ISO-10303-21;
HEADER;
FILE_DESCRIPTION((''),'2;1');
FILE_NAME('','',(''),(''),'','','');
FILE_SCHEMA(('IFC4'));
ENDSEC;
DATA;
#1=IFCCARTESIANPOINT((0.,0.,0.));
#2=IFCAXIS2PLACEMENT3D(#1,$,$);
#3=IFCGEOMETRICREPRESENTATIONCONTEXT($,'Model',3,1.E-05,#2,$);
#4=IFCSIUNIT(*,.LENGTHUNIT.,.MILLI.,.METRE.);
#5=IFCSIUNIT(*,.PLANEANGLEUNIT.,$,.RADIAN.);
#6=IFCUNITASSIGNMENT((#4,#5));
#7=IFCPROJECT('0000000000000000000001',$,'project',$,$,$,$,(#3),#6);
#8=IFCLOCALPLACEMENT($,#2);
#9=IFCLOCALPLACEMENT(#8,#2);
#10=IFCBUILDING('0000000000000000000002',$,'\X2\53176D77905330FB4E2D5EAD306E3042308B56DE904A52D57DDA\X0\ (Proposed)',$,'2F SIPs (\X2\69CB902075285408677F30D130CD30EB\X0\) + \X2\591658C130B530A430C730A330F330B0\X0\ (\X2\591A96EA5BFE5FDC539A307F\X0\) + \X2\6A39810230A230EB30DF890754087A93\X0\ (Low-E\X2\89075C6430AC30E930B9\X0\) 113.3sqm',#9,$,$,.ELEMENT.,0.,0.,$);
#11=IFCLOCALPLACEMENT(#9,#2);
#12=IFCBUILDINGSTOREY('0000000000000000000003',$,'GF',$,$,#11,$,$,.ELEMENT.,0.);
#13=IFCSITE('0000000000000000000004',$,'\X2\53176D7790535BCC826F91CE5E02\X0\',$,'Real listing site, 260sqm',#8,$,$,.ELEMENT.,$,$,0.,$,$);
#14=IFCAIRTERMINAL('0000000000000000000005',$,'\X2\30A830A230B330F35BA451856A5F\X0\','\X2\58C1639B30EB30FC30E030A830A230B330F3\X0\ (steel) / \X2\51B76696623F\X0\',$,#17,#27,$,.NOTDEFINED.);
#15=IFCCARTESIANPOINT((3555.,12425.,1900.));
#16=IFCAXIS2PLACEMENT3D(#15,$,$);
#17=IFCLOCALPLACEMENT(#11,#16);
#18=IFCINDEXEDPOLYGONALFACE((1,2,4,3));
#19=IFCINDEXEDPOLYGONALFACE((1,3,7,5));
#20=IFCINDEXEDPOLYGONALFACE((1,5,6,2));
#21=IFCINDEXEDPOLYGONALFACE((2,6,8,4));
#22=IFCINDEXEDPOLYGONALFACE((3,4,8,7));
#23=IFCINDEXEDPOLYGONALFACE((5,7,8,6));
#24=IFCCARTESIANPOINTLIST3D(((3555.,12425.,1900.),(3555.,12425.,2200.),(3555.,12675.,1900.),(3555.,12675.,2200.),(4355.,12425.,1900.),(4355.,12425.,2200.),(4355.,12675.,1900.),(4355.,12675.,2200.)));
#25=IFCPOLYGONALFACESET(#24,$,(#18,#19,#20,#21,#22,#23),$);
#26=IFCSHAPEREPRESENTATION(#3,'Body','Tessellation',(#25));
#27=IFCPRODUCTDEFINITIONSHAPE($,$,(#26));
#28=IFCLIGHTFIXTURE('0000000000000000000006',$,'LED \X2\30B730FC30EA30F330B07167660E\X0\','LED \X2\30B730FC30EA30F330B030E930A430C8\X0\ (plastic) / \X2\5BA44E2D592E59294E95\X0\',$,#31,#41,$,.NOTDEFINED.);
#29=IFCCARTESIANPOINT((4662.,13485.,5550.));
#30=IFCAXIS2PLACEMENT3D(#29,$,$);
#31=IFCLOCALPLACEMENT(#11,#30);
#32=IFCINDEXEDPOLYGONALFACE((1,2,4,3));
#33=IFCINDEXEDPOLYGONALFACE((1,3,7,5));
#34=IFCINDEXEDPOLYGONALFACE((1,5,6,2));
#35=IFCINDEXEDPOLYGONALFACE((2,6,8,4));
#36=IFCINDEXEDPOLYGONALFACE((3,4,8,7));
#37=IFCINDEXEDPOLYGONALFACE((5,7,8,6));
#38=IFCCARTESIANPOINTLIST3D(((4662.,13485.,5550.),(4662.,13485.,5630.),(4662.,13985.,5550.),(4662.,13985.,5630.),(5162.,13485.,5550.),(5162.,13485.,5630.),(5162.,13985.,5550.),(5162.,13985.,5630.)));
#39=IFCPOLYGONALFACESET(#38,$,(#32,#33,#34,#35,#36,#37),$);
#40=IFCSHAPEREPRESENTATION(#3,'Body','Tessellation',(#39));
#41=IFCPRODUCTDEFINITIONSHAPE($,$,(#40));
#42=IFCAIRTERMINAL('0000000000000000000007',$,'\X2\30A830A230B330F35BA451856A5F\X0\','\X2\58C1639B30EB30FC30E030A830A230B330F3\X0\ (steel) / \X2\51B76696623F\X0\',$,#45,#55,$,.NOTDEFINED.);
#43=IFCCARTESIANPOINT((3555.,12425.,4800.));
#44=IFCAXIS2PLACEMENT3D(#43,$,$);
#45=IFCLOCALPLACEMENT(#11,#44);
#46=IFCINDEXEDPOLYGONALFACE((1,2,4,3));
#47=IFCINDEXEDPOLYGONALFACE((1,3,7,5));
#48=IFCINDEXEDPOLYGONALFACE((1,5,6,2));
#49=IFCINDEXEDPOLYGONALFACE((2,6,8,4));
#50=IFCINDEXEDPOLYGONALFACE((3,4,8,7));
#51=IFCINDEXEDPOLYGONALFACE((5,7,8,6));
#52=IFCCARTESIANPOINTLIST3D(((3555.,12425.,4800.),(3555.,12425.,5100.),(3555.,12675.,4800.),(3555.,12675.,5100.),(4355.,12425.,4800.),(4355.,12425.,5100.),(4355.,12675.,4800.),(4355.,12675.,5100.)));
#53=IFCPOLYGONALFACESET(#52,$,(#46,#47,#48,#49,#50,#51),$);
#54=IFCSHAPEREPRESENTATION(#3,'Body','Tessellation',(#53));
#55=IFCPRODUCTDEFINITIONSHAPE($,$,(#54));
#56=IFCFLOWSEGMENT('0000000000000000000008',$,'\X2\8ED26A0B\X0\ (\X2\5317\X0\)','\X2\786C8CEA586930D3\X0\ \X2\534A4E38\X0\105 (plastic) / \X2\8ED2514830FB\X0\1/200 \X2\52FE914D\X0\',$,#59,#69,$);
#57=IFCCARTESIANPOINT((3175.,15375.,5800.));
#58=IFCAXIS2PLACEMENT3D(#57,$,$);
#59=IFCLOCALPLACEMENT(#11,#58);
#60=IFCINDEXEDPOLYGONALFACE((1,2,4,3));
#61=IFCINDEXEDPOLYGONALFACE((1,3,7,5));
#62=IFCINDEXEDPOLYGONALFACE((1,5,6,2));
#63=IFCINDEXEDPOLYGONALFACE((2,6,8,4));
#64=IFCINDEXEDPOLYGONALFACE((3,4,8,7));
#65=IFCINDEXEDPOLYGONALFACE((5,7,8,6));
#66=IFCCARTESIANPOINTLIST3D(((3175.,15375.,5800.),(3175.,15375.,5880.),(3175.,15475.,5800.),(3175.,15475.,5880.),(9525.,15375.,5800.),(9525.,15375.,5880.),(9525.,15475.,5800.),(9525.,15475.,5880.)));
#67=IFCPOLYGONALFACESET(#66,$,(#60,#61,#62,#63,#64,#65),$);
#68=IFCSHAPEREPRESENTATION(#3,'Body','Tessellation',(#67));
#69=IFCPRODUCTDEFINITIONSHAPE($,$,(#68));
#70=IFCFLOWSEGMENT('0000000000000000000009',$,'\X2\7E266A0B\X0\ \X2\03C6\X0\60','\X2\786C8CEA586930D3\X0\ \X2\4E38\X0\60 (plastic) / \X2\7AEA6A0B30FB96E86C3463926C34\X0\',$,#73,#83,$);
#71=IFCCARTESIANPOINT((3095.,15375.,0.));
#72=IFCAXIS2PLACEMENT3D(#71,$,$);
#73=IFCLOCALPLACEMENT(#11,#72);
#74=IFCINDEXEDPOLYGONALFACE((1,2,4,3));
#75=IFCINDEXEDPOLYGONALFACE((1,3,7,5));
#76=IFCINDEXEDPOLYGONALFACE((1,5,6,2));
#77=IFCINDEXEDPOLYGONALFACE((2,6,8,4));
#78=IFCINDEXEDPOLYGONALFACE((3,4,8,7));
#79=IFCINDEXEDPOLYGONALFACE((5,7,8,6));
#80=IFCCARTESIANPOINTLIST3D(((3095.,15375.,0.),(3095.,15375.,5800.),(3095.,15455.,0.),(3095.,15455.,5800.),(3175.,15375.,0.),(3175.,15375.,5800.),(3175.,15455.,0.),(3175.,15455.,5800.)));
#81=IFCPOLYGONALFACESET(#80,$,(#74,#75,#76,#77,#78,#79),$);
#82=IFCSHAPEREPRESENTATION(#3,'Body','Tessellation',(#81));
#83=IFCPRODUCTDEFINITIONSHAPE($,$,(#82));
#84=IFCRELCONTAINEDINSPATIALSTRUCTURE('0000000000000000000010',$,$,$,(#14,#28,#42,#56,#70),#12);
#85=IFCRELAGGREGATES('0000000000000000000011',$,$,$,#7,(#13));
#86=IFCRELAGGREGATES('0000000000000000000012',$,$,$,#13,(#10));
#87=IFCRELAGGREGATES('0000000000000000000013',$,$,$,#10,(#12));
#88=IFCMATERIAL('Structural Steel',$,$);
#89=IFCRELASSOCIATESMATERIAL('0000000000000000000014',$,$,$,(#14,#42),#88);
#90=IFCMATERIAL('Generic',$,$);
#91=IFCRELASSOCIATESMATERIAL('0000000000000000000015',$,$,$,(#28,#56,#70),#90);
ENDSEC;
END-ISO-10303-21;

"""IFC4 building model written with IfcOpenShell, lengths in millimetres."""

from ifc_helpers import new_model, si_unit, frame, frame_2d, origin, place, context, project, spatial, rectangle, extrude, material, element, save


model = new_model("IFC4")

# Units and contexts
model_context = context("Model", 3, precision=1e-05, world=origin())
ifc_project = project(units=[si_unit("LENGTHUNIT", "METRE", prefix="MILLI"), si_unit("PLANEANGLEUNIT", "RADIAN")], contexts=[model_context])

# Site, building, storey
site_placement = place(None, origin())
site = spatial("IfcSite", under=ifc_project, at=site_placement, Name="北海道富良野市", ObjectType="Real listing site, 260sqm", CompositionType="ELEMENT", RefElevation=0.0)
building_placement = place(site_placement, origin())
building = spatial("IfcBuilding", under=site, at=building_placement, Name="北海道・中庭のある回遊動線 (Proposed)", ObjectType="2F SIPs (構造用合板パネル) + 外壁サイディング (多雪対応厚み) + 樹脂アルミ複合窓 (Low-E複層ガラス) 113.3sqm", CompositionType="ELEMENT", ElevationOfRefHeight=0.0, ElevationOfTerrain=0.0)
storey_placement = place(building_placement, origin())
storey = spatial("IfcBuildingStorey", under=building, at=storey_placement, Name="GF", CompositionType="ELEMENT", Elevation=0.0)

# Shared definitions
ifc_material_1 = material(Name="Generic")

# Shared definitions
ifc_material_2 = material(Name="Structural Steel")

# Air terminal
air_terminal_1_placement = place(storey_placement, frame((3555.0, 12425.0, 1900.0)))
element("IfcAirTerminal", 1, at=air_terminal_1_placement, inside=storey, material=ifc_material_2, Name="エアコン室内機", Description="壁掛ルームエアコン (steel) / 冷暖房", PredefinedType="NOTDEFINED", context=model_context, shape_type="SweptSolid", body=[
    extrude(rectangle(XDim=800.0, YDim=250.0, at=frame_2d((400.0, 125.0))), frame((3555.0, 12425.0, 1900.0)), (0.0, 0.0, 1.0), 300.0),
])

# Light fixture
light_fixture_placement = place(storey_placement, frame((4662.0, 13485.0, 5550.0)))
element("IfcLightFixture", 2, at=light_fixture_placement, inside=storey, material=ifc_material_1, Name="LED シーリング照明", Description="LED シーリングライト (plastic) / 室中央天井", PredefinedType="NOTDEFINED", context=model_context, shape_type="SweptSolid", body=[
    extrude(rectangle(XDim=500.0, YDim=500.0, at=frame_2d((250.0, 250.0))), frame((4662.0, 13485.0, 5550.0)), (0.0, 0.0, 1.0), 80.0),
])

# Air terminal
air_terminal_2_placement = place(storey_placement, frame((3555.0, 12425.0, 4800.0)))
element("IfcAirTerminal", 3, at=air_terminal_2_placement, inside=storey, material=ifc_material_2, Name="エアコン室内機", Description="壁掛ルームエアコン (steel) / 冷暖房", PredefinedType="NOTDEFINED", context=model_context, shape_type="SweptSolid", body=[
    extrude(rectangle(XDim=800.0, YDim=250.0, at=frame_2d((400.0, 125.0))), frame((3555.0, 12425.0, 4800.0)), (0.0, 0.0, 1.0), 300.0),
])

# Flow segments
flow_segment_1_placement = place(storey_placement, frame((3175.0, 15375.0, 5800.0)))
element("IfcFlowSegment", 4, at=flow_segment_1_placement, inside=storey, material=ifc_material_1, Name="軒樋 (北)", Description="硬質塩ビ 半丸105 (plastic) / 軒先・1/200 勾配", context=model_context, shape_type="SweptSolid", body=[
    extrude(rectangle(XDim=6350.0, YDim=100.0, at=frame_2d((3175.0, 50.0))), frame((3175.0, 15375.0, 5800.0)), (0.0, 0.0, 1.0), 80.0),
])
flow_segment_2_placement = place(storey_placement, frame((3095.0, 15375.0, 0.0)))
element("IfcFlowSegment", 5, at=flow_segment_2_placement, inside=storey, material=ifc_material_1, Name="縦樋 φ60", Description="硬質塩ビ 丸60 (plastic) / 竪樋・雨水排水", context=model_context, shape_type="SweptSolid", body=[
    extrude(rectangle(XDim=80.0, YDim=80.0, at=frame_2d((40.0, 40.0))), frame((3095.0, 15375.0, 0.0)), (0.0, 0.0, 1.0), 5800.0),
])

save(model, "model.ifc")
